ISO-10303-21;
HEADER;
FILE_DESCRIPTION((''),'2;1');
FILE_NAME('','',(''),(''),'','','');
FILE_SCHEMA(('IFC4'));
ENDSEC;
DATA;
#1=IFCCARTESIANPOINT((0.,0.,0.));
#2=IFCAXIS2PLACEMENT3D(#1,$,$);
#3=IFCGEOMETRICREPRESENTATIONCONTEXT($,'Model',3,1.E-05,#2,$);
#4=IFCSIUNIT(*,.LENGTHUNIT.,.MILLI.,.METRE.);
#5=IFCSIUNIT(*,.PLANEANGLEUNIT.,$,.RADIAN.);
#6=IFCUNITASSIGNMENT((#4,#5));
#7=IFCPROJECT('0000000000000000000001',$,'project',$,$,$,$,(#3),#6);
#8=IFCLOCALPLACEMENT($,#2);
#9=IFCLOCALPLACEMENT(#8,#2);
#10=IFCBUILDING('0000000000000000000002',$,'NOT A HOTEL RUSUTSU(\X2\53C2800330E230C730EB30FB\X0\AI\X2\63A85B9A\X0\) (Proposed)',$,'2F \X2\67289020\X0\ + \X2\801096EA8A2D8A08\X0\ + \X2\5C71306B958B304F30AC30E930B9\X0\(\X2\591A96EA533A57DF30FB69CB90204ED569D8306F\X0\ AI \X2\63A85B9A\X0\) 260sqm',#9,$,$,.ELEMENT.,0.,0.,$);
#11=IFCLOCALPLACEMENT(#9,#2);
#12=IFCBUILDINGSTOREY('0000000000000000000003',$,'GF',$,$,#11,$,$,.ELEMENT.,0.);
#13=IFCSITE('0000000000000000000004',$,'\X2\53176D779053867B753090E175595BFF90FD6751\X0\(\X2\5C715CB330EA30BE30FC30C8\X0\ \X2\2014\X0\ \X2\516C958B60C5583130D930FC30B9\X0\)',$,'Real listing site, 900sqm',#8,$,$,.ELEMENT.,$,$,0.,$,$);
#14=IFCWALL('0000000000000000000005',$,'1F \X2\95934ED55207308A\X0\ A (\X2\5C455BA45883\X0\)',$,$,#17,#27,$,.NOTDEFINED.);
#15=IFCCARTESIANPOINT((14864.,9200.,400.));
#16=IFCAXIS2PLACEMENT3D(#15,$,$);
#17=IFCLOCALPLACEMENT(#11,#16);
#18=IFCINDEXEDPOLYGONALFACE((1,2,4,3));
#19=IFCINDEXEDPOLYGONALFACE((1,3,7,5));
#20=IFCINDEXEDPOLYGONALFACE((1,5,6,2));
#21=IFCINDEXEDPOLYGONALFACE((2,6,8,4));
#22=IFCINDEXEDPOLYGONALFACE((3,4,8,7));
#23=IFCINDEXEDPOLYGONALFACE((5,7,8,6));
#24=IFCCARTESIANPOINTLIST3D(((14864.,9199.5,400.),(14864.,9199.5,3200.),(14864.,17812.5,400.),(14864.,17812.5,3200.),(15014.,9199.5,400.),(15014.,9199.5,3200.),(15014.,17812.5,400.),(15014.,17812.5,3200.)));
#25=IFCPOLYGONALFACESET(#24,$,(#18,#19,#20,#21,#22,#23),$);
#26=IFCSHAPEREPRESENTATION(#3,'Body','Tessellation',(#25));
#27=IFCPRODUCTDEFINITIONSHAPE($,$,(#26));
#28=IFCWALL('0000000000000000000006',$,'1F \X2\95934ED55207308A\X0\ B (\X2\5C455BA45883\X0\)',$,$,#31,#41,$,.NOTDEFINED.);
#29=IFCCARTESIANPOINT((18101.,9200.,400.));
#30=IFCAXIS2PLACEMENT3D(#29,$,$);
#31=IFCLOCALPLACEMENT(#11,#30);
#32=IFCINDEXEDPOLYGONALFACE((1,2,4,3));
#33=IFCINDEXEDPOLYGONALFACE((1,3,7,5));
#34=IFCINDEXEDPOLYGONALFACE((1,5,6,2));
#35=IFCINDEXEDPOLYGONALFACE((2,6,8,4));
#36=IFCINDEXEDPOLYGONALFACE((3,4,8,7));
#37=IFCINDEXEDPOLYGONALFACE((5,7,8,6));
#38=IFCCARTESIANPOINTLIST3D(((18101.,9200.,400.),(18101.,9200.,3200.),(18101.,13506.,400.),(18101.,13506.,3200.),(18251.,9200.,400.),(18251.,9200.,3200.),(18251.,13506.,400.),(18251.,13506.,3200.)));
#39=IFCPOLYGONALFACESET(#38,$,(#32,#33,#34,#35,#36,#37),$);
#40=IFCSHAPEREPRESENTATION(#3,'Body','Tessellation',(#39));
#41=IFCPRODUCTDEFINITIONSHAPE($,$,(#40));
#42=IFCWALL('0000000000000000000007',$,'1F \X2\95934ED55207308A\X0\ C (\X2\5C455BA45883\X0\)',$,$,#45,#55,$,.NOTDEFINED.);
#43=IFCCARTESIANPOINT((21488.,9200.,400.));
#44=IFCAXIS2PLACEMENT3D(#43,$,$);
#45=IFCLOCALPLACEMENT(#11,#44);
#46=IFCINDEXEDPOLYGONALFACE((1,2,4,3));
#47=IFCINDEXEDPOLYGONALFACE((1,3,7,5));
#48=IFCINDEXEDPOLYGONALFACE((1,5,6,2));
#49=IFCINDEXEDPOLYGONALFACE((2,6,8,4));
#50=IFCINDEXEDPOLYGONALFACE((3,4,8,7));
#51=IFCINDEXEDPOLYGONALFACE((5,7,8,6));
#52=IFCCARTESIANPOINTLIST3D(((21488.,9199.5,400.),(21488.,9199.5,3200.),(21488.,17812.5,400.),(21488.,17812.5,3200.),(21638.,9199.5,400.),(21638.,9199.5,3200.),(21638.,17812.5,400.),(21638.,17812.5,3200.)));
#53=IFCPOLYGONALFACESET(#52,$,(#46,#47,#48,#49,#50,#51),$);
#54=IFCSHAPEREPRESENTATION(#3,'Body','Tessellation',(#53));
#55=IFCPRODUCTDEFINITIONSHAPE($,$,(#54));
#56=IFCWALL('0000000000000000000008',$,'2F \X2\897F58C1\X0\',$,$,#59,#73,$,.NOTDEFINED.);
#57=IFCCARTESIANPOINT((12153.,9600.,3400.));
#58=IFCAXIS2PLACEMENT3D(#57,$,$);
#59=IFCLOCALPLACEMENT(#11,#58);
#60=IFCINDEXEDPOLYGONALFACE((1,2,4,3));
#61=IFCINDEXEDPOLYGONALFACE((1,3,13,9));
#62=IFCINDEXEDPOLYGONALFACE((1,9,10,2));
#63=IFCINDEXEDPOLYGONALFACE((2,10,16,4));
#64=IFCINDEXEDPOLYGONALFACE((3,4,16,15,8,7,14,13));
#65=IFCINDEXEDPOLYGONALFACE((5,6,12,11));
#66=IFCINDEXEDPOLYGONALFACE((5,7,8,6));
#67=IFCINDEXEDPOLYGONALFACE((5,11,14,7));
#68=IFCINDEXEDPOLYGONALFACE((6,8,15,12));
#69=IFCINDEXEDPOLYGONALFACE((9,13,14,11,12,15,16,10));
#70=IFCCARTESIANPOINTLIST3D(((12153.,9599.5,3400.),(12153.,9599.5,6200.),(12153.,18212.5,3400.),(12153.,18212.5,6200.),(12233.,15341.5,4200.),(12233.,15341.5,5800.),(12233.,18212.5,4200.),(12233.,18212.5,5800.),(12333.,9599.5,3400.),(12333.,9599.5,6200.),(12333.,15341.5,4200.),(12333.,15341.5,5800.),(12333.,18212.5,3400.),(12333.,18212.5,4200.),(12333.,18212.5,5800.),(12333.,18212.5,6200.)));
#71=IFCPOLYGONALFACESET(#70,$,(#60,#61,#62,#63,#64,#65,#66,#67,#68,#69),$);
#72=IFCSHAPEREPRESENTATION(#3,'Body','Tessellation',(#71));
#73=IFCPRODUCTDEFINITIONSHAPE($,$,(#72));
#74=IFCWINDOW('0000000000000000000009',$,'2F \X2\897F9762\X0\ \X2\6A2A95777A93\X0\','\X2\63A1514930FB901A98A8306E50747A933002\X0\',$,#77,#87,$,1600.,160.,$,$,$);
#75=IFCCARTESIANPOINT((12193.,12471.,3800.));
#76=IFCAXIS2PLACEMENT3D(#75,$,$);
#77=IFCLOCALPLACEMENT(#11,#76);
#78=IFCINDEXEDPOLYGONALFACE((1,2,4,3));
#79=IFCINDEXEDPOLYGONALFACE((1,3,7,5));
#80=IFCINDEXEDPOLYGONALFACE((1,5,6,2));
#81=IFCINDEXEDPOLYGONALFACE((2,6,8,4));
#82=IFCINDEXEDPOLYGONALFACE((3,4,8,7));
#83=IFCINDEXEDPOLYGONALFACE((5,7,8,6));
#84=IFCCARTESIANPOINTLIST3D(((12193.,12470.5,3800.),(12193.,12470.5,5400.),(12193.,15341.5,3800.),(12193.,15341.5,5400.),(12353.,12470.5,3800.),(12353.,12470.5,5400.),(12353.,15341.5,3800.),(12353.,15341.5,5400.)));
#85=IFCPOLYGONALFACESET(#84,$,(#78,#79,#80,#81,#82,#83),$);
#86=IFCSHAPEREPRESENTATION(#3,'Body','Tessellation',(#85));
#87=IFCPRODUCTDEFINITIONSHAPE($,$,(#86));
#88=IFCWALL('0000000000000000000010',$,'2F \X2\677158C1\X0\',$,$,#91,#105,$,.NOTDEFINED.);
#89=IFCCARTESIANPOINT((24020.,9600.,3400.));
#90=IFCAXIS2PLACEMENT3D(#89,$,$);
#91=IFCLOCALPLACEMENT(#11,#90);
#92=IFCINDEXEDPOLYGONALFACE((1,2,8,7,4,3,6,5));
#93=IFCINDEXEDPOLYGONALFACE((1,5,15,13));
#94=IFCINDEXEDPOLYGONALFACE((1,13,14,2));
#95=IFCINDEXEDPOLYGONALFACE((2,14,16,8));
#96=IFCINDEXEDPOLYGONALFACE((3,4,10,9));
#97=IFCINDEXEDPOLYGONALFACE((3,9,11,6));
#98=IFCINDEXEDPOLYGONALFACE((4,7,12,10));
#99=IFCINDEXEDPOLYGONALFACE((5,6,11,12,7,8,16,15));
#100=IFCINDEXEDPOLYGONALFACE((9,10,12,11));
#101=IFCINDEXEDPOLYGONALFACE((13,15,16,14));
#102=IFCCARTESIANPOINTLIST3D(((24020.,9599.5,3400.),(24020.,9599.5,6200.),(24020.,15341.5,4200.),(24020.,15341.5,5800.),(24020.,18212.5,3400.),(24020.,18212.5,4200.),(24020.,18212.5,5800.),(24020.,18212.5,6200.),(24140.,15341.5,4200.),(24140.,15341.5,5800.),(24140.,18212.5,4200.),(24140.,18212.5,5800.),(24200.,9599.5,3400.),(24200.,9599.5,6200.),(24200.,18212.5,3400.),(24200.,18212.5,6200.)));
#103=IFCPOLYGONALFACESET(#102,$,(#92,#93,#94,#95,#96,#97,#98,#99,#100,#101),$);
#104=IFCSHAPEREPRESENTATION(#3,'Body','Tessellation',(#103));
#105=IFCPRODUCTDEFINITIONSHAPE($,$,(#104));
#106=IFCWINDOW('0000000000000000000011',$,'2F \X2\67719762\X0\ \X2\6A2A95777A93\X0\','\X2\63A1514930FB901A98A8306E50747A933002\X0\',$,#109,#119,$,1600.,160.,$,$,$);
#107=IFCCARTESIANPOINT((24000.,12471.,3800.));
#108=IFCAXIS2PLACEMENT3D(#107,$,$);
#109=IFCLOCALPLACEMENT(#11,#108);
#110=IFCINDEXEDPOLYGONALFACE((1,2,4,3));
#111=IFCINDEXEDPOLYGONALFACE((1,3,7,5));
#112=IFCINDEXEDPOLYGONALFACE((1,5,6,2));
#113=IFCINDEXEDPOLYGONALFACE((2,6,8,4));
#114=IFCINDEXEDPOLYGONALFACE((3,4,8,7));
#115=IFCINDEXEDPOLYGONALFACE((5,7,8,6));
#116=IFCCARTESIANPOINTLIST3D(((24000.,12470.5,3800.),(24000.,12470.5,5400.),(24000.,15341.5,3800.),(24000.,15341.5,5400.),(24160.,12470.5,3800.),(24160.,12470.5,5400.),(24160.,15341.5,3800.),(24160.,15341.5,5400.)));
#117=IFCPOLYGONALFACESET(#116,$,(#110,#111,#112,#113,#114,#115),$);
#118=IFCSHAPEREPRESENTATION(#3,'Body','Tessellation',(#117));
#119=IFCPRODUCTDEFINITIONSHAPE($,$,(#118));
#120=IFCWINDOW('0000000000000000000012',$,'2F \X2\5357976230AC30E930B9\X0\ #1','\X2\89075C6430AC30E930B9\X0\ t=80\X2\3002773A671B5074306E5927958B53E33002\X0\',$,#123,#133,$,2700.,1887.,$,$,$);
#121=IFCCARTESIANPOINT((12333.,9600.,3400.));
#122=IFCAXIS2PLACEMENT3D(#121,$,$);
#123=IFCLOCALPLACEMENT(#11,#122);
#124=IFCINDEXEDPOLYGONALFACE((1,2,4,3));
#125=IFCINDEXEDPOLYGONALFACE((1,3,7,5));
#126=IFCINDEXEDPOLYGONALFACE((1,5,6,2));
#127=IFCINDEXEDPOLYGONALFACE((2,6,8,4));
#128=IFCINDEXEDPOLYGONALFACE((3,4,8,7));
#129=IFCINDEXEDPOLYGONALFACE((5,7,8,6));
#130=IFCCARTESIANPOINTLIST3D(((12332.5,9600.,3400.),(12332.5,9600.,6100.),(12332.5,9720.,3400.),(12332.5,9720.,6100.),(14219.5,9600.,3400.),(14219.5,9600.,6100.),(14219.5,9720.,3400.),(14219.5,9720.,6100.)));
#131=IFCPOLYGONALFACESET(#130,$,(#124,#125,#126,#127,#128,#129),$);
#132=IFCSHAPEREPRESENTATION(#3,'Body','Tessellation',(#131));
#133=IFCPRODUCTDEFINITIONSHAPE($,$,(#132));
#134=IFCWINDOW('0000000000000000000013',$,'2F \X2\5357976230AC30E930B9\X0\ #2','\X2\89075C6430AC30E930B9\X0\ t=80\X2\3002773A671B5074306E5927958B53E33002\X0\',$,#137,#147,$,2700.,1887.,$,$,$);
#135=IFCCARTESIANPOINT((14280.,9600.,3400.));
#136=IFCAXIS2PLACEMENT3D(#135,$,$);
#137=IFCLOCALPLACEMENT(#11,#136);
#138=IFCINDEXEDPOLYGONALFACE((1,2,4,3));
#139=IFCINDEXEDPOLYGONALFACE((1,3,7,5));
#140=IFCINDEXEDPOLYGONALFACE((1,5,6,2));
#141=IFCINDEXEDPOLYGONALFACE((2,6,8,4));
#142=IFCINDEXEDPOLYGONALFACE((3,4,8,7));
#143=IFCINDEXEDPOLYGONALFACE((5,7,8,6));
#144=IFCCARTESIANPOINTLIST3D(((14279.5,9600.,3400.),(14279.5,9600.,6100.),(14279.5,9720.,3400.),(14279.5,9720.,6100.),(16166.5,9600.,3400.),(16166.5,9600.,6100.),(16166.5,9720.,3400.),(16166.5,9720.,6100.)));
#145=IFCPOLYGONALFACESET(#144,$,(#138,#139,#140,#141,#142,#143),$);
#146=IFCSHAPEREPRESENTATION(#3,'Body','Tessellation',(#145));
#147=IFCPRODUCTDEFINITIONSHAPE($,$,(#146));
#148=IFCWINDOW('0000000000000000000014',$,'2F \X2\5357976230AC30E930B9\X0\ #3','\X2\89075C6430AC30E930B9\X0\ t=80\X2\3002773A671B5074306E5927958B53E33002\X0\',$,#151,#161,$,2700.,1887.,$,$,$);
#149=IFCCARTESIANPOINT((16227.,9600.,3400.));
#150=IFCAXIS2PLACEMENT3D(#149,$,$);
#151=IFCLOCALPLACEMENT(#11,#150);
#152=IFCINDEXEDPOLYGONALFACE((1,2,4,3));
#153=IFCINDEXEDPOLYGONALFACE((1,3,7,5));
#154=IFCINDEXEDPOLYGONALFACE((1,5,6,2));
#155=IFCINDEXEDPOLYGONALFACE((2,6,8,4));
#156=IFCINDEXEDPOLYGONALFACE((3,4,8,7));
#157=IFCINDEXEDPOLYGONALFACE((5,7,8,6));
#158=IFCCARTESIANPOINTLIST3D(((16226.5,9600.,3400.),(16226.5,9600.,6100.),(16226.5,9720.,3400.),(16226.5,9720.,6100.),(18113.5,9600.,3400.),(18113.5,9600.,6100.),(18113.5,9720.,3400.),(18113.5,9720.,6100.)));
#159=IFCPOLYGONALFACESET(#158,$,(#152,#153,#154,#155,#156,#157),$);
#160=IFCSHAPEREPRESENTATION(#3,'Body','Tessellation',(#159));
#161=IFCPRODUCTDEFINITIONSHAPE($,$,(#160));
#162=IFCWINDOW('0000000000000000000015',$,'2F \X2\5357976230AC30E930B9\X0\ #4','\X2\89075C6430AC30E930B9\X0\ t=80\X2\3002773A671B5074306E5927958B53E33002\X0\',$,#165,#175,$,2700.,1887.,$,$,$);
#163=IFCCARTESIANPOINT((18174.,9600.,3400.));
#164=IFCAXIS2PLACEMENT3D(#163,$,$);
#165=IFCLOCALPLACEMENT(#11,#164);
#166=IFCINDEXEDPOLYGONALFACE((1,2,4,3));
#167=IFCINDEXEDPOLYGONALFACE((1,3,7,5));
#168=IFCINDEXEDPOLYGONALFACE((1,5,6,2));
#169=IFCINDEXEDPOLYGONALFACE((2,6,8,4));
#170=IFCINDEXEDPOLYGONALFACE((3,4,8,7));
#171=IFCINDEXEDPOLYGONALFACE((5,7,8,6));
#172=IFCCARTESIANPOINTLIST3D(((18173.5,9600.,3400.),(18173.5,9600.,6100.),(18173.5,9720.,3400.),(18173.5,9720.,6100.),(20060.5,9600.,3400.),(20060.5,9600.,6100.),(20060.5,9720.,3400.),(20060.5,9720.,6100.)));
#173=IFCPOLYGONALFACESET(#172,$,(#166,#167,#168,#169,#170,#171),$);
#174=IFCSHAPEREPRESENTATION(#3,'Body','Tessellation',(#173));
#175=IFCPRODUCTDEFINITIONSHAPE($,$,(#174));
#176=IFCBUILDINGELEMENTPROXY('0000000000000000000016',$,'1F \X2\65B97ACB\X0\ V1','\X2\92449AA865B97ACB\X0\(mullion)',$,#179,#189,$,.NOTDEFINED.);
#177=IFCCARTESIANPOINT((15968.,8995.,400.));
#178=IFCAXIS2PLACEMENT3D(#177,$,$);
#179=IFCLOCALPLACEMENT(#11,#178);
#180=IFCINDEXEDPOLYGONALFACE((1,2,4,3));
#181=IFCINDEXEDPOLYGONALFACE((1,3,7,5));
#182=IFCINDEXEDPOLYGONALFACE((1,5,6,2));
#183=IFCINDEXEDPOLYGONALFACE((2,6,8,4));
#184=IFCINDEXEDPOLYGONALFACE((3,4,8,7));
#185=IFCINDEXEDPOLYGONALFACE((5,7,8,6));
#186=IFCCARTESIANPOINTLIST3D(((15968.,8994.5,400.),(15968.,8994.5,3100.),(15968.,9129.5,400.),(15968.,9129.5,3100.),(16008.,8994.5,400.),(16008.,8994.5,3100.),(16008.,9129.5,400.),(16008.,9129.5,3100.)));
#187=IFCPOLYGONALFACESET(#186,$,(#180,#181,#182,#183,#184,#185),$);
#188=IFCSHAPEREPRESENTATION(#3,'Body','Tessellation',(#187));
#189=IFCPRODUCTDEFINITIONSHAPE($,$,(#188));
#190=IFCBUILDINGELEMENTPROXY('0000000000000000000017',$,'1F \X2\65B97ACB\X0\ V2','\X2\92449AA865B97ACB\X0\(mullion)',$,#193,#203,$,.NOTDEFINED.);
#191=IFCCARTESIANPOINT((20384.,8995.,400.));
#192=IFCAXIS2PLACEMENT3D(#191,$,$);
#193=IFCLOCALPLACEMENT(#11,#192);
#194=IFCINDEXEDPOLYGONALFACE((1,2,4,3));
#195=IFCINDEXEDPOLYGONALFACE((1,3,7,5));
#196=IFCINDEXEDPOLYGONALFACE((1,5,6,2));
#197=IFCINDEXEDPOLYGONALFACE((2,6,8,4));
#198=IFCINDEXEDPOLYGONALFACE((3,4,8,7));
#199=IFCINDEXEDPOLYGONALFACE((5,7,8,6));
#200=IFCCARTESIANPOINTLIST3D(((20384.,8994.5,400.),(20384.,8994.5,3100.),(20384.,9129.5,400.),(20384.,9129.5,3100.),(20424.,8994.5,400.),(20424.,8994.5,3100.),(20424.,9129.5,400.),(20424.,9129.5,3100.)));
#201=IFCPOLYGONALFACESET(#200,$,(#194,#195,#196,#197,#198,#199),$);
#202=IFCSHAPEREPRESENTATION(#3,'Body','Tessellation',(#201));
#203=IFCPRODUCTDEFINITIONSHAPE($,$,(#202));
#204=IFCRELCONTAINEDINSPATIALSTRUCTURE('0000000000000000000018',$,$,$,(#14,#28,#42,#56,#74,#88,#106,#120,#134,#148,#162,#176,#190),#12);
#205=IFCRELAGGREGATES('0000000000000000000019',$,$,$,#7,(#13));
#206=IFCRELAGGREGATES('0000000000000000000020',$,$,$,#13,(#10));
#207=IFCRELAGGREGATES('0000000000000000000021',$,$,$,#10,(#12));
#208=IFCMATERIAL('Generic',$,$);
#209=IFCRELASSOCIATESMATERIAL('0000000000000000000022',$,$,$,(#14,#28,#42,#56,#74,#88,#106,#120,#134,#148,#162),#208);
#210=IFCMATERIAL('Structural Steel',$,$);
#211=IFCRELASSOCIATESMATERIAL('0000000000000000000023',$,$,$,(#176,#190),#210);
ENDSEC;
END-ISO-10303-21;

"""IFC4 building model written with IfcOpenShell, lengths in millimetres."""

from ifc_helpers import new_model, si_unit, frame, frame_2d, origin, place, context, project, spatial, rectangle, extrude, material, element, fill, save


model = new_model("IFC4")

# Units and contexts
model_context = context("Model", 3, precision=1e-05, world=origin())
ifc_project = project(units=[si_unit("LENGTHUNIT", "METRE", prefix="MILLI"), si_unit("PLANEANGLEUNIT", "RADIAN")], contexts=[model_context])

# Site, building, storey
site_placement = place(None, origin())
site = spatial("IfcSite", under=ifc_project, at=site_placement, Name="北海道虻田郡留寿都村(山岳リゾート — 公開情報ベース)", ObjectType="Real listing site, 900sqm", CompositionType="ELEMENT", RefElevation=0.0)
building_placement = place(site_placement, origin())
building = spatial("IfcBuilding", under=site, at=building_placement, Name="NOT A HOTEL RUSUTSU(参考モデル・AI推定) (Proposed)", ObjectType="2F 木造 + 耐雪設計 + 山に開くガラス(多雪区域・構造仕様は AI 推定) 260sqm", CompositionType="ELEMENT", ElevationOfRefHeight=0.0, ElevationOfTerrain=0.0)
storey_placement = place(building_placement, origin())
storey = spatial("IfcBuildingStorey", under=building, at=storey_placement, Name="GF", CompositionType="ELEMENT", Elevation=0.0)

# Shared definitions
ifc_material_1 = material(Name="Generic")

# Walls
wall_1_placement = place(storey_placement, frame((14864.0, 9200.0, 400.0)))
element("IfcWall", 1, at=wall_1_placement, inside=storey, material=ifc_material_1, Name="1F 間仕切り A (居室境)", PredefinedType="NOTDEFINED", context=model_context, shape_type="SweptSolid", body=[
    extrude(rectangle(XDim=150.0, YDim=8613.0, at=frame_2d((75.0, 4306.0))), frame((14864.0, 9200.0, 400.0)), (0.0, 0.0, 1.0), 2800.0),
])
wall_2_placement = place(storey_placement, frame((18101.0, 9200.0, 400.0)))
element("IfcWall", 2, at=wall_2_placement, inside=storey, material=ifc_material_1, Name="1F 間仕切り B (居室境)", PredefinedType="NOTDEFINED", context=model_context, shape_type="SweptSolid", body=[
    extrude(rectangle(XDim=150.0, YDim=4306.0, at=frame_2d((75.0, 2153.0))), frame((18101.0, 9200.0, 400.0)), (0.0, 0.0, 1.0), 2800.0),
])
wall_3_placement = place(storey_placement, frame((21488.0, 9200.0, 400.0)))
element("IfcWall", 3, at=wall_3_placement, inside=storey, material=ifc_material_1, Name="1F 間仕切り C (居室境)", PredefinedType="NOTDEFINED", context=model_context, shape_type="SweptSolid", body=[
    extrude(rectangle(XDim=150.0, YDim=8613.0, at=frame_2d((75.0, 4306.0))), frame((21488.0, 9200.0, 400.0)), (0.0, 0.0, 1.0), 2800.0),
])

# Walls, openings, windows
wall_4_placement = place(storey_placement, frame((12153.0, 9600.0, 3400.0)))
wall_4 = element("IfcWall", 4, at=wall_4_placement, inside=storey, material=ifc_material_1, Name="2F 西壁", PredefinedType="NOTDEFINED", context=model_context, shape_type="SweptSolid", body=[
    extrude(rectangle(XDim=180.0, YDim=8613.0, at=frame_2d((90.0, 4306.0))), frame((12153.0, 9600.0, 3400.0)), (0.0, 0.0, 1.0), 2800.0),
])
opening_1_placement = place(storey_placement, frame((12193.0, 12471.0, 3800.0)))
opening_1 = element("IfcOpeningElement", 5, at=opening_1_placement, cuts=wall_4, PredefinedType="NOTDEFINED", context=model_context, shape_type="SweptSolid", body=[
    extrude(rectangle(XDim=160.0, YDim=2871.0, at=frame_2d((80.0, 1435.0))), frame((12193.0, 12471.0, 3800.0)), (0.0, 0.0, 1.0), 1600.0),
])
window_1_placement = place(storey_placement, frame((12193.0, 12471.0, 3800.0)))
window_1 = element("IfcWindow", 6, at=window_1_placement, inside=storey, material=ifc_material_1, Name="2F 西面 横長窓", Description="採光・通風の側窓。", OverallHeight=1600.0, OverallWidth=160.0, context=model_context, shape_type="SweptSolid", body=[
    extrude(rectangle(XDim=160.0, YDim=2871.0, at=frame_2d((80.0, 1435.0))), frame((12193.0, 12471.0, 3800.0)), (0.0, 0.0, 1.0), 1600.0),
])
fill(opening_1, window_1)
wall_5_placement = place(storey_placement, frame((24020.0, 9600.0, 3400.0)))
wall_5 = element("IfcWall", 7, at=wall_5_placement, inside=storey, material=ifc_material_1, Name="2F 東壁", PredefinedType="NOTDEFINED", context=model_context, shape_type="SweptSolid", body=[
    extrude(rectangle(XDim=180.0, YDim=8613.0, at=frame_2d((90.0, 4306.0))), frame((24020.0, 9600.0, 3400.0)), (0.0, 0.0, 1.0), 2800.0),
])
opening_2_placement = place(storey_placement, frame((24000.0, 12471.0, 3800.0)))
opening_2 = element("IfcOpeningElement", 8, at=opening_2_placement, cuts=wall_5, PredefinedType="NOTDEFINED", context=model_context, shape_type="SweptSolid", body=[
    extrude(rectangle(XDim=160.0, YDim=2871.0, at=frame_2d((80.0, 1435.0))), frame((24000.0, 12471.0, 3800.0)), (0.0, 0.0, 1.0), 1600.0),
])
window_2_placement = place(storey_placement, frame((24000.0, 12471.0, 3800.0)))
window_2 = element("IfcWindow", 9, at=window_2_placement, inside=storey, material=ifc_material_1, Name="2F 東面 横長窓", Description="採光・通風の側窓。", OverallHeight=1600.0, OverallWidth=160.0, context=model_context, shape_type="SweptSolid", body=[
    extrude(rectangle(XDim=160.0, YDim=2871.0, at=frame_2d((80.0, 1435.0))), frame((24000.0, 12471.0, 3800.0)), (0.0, 0.0, 1.0), 1600.0),
])
fill(opening_2, window_2)

# Windows
window_3_placement = place(storey_placement, frame((12333.0, 9600.0, 3400.0)))
element("IfcWindow", 10, at=window_3_placement, inside=storey, material=ifc_material_1, Name="2F 南面ガラス #1", Description="複層ガラス t=80。眺望側の大開口。", OverallHeight=2700.0, OverallWidth=1887.0, context=model_context, shape_type="SweptSolid", body=[
    extrude(rectangle(XDim=1887.0, YDim=120.0, at=frame_2d((943.0, 60.0))), frame((12333.0, 9600.0, 3400.0)), (0.0, 0.0, 1.0), 2700.0),
])
window_4_placement = place(storey_placement, frame((14280.0, 9600.0, 3400.0)))
element("IfcWindow", 11, at=window_4_placement, inside=storey, material=ifc_material_1, Name="2F 南面ガラス #2", Description="複層ガラス t=80。眺望側の大開口。", OverallHeight=2700.0, OverallWidth=1887.0, context=model_context, shape_type="SweptSolid", body=[
    extrude(rectangle(XDim=1887.0, YDim=120.0, at=frame_2d((943.0, 60.0))), frame((14280.0, 9600.0, 3400.0)), (0.0, 0.0, 1.0), 2700.0),
])
window_5_placement = place(storey_placement, frame((16227.0, 9600.0, 3400.0)))
element("IfcWindow", 12, at=window_5_placement, inside=storey, material=ifc_material_1, Name="2F 南面ガラス #3", Description="複層ガラス t=80。眺望側の大開口。", OverallHeight=2700.0, OverallWidth=1887.0, context=model_context, shape_type="SweptSolid", body=[
    extrude(rectangle(XDim=1887.0, YDim=120.0, at=frame_2d((943.0, 60.0))), frame((16227.0, 9600.0, 3400.0)), (0.0, 0.0, 1.0), 2700.0),
])
window_6_placement = place(storey_placement, frame((18174.0, 9600.0, 3400.0)))
element("IfcWindow", 13, at=window_6_placement, inside=storey, material=ifc_material_1, Name="2F 南面ガラス #4", Description="複層ガラス t=80。眺望側の大開口。", OverallHeight=2700.0, OverallWidth=1887.0, context=model_context, shape_type="SweptSolid", body=[
    extrude(rectangle(XDim=1887.0, YDim=120.0, at=frame_2d((943.0, 60.0))), frame((18174.0, 9600.0, 3400.0)), (0.0, 0.0, 1.0), 2700.0),
])

# Building element proxies
ifc_material_2 = material(Name="Structural Steel")
proxy_1_placement = place(storey_placement, frame((15968.0, 8995.0, 400.0)))
element("IfcBuildingElementProxy", 14, at=proxy_1_placement, inside=storey, material=ifc_material_2, Name="1F 方立 V1", Description="鉄骨方立(mullion)", PredefinedType="NOTDEFINED", context=model_context, shape_type="SweptSolid", body=[
    extrude(rectangle(XDim=40.0, YDim=135.0, at=frame_2d((20.0, 67.0))), frame((15968.0, 8995.0, 400.0)), (0.0, 0.0, 1.0), 2700.0),
])
proxy_2_placement = place(storey_placement, frame((20384.0, 8995.0, 400.0)))
element("IfcBuildingElementProxy", 15, at=proxy_2_placement, inside=storey, material=ifc_material_2, Name="1F 方立 V2", Description="鉄骨方立(mullion)", PredefinedType="NOTDEFINED", context=model_context, shape_type="SweptSolid", body=[
    extrude(rectangle(XDim=40.0, YDim=135.0, at=frame_2d((20.0, 67.0))), frame((20384.0, 8995.0, 400.0)), (0.0, 0.0, 1.0), 2700.0),
])

save(model, "model.ifc")
